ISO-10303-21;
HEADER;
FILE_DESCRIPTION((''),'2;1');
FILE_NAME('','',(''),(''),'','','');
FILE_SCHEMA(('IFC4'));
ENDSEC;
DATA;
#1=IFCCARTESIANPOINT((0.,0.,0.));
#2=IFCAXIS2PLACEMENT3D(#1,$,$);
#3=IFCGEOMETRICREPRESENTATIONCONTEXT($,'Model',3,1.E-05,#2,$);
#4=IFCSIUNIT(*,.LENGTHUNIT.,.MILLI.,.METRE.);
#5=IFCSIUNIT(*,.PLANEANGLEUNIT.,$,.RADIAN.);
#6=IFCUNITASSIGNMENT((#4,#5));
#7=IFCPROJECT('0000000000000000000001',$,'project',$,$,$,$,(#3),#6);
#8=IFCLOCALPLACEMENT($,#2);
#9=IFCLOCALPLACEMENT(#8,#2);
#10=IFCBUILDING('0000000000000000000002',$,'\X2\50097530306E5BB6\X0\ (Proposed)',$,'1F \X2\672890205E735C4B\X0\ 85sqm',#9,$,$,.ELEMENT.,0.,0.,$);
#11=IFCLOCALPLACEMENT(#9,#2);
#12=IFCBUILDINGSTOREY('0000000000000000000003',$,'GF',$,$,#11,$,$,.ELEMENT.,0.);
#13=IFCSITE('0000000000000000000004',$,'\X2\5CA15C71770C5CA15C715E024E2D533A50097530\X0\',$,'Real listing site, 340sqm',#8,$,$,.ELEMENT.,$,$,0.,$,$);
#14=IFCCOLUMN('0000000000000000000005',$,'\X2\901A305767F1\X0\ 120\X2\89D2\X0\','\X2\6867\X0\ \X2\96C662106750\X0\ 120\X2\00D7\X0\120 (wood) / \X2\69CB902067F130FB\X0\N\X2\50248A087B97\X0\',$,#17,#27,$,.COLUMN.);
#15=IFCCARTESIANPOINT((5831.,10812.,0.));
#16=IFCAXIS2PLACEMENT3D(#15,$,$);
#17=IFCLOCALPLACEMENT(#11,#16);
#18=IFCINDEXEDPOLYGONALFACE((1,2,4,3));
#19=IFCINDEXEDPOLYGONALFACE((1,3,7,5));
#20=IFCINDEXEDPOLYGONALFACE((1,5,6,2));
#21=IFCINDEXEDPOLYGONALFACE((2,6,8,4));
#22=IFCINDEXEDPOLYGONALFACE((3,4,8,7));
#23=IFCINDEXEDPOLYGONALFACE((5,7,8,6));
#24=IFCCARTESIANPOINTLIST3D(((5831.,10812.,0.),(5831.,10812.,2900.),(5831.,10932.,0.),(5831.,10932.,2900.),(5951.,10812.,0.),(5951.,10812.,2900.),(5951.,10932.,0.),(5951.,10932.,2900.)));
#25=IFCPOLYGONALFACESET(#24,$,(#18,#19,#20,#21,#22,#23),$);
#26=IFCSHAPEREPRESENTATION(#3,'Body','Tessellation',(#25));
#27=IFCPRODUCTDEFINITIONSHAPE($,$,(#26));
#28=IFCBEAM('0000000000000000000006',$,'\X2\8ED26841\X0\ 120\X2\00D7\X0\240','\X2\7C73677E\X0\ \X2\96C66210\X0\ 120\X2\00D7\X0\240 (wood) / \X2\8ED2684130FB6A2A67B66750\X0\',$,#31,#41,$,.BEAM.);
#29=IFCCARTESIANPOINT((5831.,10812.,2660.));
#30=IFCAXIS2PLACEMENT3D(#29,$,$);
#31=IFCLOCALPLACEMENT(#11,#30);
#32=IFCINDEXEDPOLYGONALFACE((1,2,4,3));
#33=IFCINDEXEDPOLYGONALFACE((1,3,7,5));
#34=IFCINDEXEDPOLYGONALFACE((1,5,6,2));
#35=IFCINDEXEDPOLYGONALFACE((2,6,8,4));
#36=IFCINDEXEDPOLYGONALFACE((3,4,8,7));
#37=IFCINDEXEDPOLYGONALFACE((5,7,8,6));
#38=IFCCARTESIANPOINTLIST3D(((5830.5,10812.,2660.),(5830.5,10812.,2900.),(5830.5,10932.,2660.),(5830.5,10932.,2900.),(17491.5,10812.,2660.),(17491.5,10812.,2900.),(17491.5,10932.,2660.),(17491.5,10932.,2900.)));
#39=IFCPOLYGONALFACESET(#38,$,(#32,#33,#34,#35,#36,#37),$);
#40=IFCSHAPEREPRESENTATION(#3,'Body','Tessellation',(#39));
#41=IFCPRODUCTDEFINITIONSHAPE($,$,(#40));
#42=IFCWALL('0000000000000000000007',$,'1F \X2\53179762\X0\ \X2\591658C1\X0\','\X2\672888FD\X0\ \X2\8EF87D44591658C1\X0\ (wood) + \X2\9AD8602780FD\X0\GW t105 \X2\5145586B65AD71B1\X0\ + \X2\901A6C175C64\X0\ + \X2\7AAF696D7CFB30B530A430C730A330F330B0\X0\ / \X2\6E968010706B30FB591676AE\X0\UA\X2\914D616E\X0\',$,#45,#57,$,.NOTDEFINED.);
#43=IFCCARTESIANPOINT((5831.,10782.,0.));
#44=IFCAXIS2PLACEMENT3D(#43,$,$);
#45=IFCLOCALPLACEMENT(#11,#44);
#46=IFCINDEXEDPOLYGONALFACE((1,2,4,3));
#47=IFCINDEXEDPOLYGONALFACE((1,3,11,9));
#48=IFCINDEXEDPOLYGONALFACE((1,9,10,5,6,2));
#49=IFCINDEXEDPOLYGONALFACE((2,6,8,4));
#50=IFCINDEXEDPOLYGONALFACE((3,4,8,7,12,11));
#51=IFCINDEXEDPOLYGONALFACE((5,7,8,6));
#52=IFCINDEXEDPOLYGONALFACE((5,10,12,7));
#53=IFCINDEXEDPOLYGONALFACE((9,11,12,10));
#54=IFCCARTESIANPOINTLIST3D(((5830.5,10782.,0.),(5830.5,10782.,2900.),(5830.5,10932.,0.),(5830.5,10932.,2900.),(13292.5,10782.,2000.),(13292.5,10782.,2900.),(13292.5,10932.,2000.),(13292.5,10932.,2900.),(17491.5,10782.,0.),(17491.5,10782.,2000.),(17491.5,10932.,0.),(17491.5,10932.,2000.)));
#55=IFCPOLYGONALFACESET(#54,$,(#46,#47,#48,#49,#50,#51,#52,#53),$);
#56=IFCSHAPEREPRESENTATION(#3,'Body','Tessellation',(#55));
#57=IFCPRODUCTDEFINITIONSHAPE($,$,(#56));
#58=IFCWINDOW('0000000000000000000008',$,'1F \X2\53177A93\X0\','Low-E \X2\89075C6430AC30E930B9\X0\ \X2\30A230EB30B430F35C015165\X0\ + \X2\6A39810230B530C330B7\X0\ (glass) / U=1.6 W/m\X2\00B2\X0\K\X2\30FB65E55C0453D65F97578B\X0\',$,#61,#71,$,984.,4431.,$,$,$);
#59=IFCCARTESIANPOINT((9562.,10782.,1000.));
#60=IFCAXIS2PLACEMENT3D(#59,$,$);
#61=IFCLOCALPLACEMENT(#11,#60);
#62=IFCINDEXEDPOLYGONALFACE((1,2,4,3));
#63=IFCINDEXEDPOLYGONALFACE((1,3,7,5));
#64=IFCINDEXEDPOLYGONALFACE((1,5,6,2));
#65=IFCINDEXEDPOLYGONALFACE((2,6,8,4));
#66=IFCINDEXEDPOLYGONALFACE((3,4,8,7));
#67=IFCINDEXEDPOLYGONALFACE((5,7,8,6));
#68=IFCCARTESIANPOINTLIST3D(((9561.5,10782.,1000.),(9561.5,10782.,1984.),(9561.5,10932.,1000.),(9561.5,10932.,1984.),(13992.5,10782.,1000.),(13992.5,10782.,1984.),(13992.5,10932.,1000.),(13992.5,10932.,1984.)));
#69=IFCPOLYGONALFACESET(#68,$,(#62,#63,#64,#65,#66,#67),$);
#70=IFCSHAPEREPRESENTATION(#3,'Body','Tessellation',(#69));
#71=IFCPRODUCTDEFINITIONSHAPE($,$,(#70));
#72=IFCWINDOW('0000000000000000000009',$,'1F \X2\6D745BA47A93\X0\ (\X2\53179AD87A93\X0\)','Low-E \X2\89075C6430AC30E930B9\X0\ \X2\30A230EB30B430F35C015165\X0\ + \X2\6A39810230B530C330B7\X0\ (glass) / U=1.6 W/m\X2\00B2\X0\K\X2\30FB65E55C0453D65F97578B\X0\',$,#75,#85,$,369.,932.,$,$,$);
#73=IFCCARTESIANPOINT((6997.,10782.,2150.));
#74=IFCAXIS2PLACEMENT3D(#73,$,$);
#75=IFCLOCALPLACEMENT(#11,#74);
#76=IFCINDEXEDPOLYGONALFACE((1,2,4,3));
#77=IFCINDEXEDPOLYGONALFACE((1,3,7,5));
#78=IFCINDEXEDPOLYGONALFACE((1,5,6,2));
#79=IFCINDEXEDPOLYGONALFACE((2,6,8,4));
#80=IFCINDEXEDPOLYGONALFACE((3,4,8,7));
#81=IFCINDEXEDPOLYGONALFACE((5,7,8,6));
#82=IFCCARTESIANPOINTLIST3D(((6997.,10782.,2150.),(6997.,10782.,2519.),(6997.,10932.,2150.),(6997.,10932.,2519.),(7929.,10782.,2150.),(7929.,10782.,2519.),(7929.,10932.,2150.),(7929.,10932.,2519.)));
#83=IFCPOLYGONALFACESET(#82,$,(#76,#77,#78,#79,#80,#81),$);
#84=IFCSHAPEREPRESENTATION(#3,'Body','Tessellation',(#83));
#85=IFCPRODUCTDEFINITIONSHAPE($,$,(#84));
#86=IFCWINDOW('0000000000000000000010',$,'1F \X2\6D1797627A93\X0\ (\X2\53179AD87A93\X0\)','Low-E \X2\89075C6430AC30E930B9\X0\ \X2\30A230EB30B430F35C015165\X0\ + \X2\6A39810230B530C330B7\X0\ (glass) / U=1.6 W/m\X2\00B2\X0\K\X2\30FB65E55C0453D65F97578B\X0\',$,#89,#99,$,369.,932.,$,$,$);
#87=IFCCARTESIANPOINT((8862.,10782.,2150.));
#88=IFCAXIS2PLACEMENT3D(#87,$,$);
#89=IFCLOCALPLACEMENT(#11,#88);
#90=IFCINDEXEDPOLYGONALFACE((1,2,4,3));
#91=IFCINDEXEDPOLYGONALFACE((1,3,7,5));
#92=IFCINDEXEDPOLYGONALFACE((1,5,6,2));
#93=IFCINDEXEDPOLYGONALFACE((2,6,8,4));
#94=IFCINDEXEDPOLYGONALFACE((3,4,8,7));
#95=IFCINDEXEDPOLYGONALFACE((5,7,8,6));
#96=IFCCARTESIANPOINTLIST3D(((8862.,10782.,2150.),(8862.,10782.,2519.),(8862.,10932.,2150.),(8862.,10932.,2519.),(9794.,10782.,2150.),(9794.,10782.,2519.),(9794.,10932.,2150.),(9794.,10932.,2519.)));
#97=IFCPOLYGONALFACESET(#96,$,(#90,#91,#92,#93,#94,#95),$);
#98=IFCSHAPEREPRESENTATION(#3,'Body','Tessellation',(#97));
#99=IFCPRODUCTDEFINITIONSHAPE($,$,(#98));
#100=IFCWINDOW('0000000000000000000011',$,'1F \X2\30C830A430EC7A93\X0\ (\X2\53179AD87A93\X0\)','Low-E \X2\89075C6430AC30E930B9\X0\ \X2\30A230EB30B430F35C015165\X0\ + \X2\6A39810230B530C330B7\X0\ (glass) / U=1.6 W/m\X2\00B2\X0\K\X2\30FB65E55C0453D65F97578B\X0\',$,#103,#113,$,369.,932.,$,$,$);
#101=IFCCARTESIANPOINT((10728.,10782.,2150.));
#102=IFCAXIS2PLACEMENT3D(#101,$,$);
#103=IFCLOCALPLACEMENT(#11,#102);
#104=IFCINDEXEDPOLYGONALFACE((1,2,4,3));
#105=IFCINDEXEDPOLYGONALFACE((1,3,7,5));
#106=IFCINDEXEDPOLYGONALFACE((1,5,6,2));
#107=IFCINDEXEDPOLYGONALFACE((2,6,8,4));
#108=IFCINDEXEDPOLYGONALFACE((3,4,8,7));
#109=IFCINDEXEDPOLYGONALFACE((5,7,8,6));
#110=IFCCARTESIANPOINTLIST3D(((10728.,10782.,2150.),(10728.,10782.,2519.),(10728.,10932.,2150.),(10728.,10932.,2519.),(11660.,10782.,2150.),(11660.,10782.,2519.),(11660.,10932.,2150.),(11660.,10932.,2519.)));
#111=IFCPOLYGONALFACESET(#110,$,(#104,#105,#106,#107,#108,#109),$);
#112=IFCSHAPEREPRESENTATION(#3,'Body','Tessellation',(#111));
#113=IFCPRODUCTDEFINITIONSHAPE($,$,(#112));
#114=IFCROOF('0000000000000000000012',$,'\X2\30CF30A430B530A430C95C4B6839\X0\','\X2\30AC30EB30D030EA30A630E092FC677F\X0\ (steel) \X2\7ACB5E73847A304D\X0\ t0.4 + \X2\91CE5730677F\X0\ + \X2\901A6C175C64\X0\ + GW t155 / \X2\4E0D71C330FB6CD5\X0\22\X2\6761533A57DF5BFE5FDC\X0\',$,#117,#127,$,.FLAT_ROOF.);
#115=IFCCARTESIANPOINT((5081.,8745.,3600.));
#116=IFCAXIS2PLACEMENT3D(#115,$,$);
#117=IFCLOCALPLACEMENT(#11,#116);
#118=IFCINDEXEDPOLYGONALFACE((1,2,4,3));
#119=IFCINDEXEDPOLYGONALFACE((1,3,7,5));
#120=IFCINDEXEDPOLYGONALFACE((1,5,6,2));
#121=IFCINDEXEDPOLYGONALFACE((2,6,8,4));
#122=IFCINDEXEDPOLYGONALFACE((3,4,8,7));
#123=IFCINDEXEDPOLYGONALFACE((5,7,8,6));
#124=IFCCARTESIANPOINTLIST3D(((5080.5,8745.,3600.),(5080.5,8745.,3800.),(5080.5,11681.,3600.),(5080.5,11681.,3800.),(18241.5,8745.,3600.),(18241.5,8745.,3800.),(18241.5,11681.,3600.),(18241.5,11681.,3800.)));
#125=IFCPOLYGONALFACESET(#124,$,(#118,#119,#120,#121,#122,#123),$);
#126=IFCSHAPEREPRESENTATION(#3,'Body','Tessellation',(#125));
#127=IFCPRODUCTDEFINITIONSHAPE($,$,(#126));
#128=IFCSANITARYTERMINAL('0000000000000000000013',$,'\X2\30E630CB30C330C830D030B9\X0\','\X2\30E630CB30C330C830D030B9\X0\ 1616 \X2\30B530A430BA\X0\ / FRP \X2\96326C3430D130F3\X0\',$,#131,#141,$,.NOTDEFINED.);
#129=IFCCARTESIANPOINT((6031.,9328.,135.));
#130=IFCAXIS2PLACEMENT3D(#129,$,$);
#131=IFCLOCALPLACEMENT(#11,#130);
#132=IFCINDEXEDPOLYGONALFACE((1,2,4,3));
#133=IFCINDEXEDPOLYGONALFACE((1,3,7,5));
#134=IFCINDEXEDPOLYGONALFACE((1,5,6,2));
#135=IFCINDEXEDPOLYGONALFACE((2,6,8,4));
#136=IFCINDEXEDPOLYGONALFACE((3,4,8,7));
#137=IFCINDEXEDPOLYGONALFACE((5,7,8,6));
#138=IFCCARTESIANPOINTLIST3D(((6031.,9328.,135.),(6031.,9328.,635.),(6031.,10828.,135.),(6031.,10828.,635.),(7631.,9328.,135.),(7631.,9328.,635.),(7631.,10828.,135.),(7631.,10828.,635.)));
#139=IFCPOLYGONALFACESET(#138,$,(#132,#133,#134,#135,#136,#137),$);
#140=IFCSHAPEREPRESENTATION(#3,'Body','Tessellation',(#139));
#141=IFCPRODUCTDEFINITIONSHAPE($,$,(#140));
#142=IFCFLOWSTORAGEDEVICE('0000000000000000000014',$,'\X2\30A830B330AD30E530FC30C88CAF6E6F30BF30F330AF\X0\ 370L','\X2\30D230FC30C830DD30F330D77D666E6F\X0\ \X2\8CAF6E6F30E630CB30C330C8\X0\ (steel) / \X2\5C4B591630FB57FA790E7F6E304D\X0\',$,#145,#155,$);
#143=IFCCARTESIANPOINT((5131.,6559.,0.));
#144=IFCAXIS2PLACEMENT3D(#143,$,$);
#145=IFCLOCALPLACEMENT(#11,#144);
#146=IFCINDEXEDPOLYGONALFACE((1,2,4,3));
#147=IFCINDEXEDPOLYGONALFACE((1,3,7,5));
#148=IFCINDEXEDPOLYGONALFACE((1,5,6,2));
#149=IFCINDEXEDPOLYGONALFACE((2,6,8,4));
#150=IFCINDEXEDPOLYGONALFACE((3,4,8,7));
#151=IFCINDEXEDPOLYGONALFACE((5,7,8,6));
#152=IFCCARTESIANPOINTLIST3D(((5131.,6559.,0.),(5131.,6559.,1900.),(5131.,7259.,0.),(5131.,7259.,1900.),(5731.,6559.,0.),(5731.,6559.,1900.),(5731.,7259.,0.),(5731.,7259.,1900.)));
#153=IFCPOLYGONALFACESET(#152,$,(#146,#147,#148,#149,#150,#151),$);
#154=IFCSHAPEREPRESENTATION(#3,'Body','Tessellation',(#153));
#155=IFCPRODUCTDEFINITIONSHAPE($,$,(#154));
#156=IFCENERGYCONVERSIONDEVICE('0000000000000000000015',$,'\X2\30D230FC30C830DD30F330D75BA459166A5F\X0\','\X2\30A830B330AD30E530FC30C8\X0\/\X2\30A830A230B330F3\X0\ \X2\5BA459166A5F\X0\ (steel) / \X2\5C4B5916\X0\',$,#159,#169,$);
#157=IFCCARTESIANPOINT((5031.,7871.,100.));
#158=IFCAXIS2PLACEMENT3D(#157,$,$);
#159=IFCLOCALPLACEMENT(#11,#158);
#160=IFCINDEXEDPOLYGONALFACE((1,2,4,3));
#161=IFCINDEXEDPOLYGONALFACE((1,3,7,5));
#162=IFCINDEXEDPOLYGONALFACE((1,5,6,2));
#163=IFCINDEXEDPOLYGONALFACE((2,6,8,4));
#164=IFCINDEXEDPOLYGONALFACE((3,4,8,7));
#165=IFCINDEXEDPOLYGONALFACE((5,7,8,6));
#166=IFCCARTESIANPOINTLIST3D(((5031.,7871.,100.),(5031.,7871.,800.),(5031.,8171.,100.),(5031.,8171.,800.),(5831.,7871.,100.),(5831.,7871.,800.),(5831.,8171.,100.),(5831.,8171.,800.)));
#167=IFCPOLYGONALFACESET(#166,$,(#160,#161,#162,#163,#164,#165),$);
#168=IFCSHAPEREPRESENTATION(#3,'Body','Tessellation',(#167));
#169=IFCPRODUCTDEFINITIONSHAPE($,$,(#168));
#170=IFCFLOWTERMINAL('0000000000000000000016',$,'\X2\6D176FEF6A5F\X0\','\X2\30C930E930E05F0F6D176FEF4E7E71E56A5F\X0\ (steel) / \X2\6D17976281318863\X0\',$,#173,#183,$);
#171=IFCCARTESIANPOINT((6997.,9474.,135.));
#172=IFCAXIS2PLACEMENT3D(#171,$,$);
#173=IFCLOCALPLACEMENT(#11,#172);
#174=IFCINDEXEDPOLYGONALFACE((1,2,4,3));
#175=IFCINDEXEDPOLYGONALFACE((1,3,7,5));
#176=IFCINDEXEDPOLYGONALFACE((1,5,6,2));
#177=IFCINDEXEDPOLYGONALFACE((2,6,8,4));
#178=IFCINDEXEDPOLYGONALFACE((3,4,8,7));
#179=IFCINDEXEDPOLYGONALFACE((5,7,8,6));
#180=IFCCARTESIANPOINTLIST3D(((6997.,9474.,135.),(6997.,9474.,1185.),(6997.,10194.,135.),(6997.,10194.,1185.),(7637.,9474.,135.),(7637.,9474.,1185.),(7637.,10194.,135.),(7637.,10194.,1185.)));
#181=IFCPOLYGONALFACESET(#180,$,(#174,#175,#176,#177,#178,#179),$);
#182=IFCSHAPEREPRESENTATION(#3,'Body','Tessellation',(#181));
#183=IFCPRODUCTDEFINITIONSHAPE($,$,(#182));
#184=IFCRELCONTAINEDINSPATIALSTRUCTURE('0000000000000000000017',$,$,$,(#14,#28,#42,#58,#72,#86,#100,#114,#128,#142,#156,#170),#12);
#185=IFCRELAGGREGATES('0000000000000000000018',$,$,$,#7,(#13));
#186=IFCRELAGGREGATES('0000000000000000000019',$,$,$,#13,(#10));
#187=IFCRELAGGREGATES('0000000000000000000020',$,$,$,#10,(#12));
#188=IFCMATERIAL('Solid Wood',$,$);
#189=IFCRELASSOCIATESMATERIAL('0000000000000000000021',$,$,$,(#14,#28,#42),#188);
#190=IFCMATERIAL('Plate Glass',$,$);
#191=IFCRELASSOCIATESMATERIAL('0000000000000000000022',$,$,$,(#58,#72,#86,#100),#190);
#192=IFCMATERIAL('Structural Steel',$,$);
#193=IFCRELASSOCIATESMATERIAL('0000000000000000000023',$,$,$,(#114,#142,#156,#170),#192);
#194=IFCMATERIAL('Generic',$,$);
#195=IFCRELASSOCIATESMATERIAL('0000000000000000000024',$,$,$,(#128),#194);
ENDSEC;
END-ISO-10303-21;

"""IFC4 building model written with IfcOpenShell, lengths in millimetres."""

from ifc_helpers import new_model, si_unit, frame, frame_2d, origin, place, context, project, spatial, rectangle, extrude, material, element, fill, save


model = new_model("IFC4")

# Units and contexts
model_context = context("Model", 3, precision=1e-05, world=origin())
ifc_project = project(units=[si_unit("LENGTHUNIT", "METRE", prefix="MILLI"), si_unit("PLANEANGLEUNIT", "RADIAN")], contexts=[model_context])

# Site, building, storey
site_placement = place(None, origin())
site = spatial("IfcSite", under=ifc_project, at=site_placement, Name="岡山県岡山市中区倉田", ObjectType="Real listing site, 340sqm", CompositionType="ELEMENT", RefElevation=0.0)
building_placement = place(site_placement, origin())
building = spatial("IfcBuilding", under=site, at=building_placement, Name="倉田の家 (Proposed)", ObjectType="1F 木造平屋 85sqm", CompositionType="ELEMENT", ElevationOfRefHeight=0.0, ElevationOfTerrain=0.0)
storey_placement = place(building_placement, origin())
storey = spatial("IfcBuildingStorey", under=building, at=storey_placement, Name="GF", CompositionType="ELEMENT", Elevation=0.0)

# Column
ifc_material_1 = material(Name="Solid Wood")
column_1_placement = place(storey_placement, frame((5831.0, 10812.0, 0.0)))
element("IfcColumn", 1, at=column_1_placement, inside=storey, material=ifc_material_1, Name="通し柱 120角", Description="桧 集成材 120×120 (wood) / 構造柱・N値計算", PredefinedType="COLUMN", context=model_context, shape_type="SweptSolid", body=[
    extrude(rectangle(XDim=120.0, YDim=120.0, at=frame_2d((60.0, 60.0))), frame((5831.0, 10812.0, 0.0)), (0.0, 0.0, 1.0), 2900.0),
])

# Beam
beam_1_placement = place(storey_placement, frame((5831.0, 10812.0, 2660.0)))
element("IfcBeam", 2, at=beam_1_placement, inside=storey, material=ifc_material_1, Name="軒桁 120×240", Description="米松 集成 120×240 (wood) / 軒桁・横架材", PredefinedType="BEAM", context=model_context, shape_type="SweptSolid", body=[
    extrude(rectangle(XDim=11661.0, YDim=120.0, at=frame_2d((5830.0, 60.0))), frame((5831.0, 10812.0, 2660.0)), (0.0, 0.0, 1.0), 240.0),
])

# Wall, openings, windows
wall_1_placement = place(storey_placement, frame((5831.0, 10782.0, 0.0)))
wall_1 = element("IfcWall", 3, at=wall_1_placement, inside=storey, material=ifc_material_1, Name="1F 北面 外壁", Description="木製 軸組外壁 (wood) + 高性能GW t105 充填断熱 + 通気層 + 窯業系サイディング / 準耐火・外皮UA配慮", PredefinedType="NOTDEFINED", context=model_context, shape_type="SweptSolid", body=[
    extrude(rectangle(XDim=11661.0, YDim=150.0, at=frame_2d((5830.0, 75.0))), frame((5831.0, 10782.0, 0.0)), (0.0, 0.0, 1.0), 2900.0),
])
opening_1_placement = place(storey_placement, frame((9562.0, 10782.0, 1000.0)))
opening_1 = element("IfcOpeningElement", 4, at=opening_1_placement, cuts=wall_1, PredefinedType="NOTDEFINED", context=model_context, shape_type="SweptSolid", body=[
    extrude(rectangle(XDim=4431.0, YDim=150.0, at=frame_2d((2215.0, 75.0))), frame((9562.0, 10782.0, 1000.0)), (0.0, 0.0, 1.0), 984.0),
])
opening_2_placement = place(storey_placement, frame((6997.0, 10782.0, 2150.0)))
opening_2 = element("IfcOpeningElement", 5, at=opening_2_placement, cuts=wall_1, PredefinedType="NOTDEFINED", context=model_context, shape_type="SweptSolid", body=[
    extrude(rectangle(XDim=932.0, YDim=150.0, at=frame_2d((466.0, 75.0))), frame((6997.0, 10782.0, 2150.0)), (0.0, 0.0, 1.0), 369.0),
])
opening_3_placement = place(storey_placement, frame((8862.0, 10782.0, 2150.0)))
opening_3 = element("IfcOpeningElement", 6, at=opening_3_placement, cuts=wall_1, PredefinedType="NOTDEFINED", context=model_context, shape_type="SweptSolid", body=[
    extrude(rectangle(XDim=932.0, YDim=150.0, at=frame_2d((466.0, 75.0))), frame((8862.0, 10782.0, 2150.0)), (0.0, 0.0, 1.0), 369.0),
])
opening_4_placement = place(storey_placement, frame((10728.0, 10782.0, 2150.0)))
opening_4 = element("IfcOpeningElement", 7, at=opening_4_placement, cuts=wall_1, PredefinedType="NOTDEFINED", context=model_context, shape_type="SweptSolid", body=[
    extrude(rectangle(XDim=932.0, YDim=150.0, at=frame_2d((466.0, 75.0))), frame((10728.0, 10782.0, 2150.0)), (0.0, 0.0, 1.0), 369.0),
])
ifc_material_2 = material(Name="Plate Glass")
window_1_placement = place(storey_placement, frame((9562.0, 10782.0, 1000.0)))
window_1 = element("IfcWindow", 8, at=window_1_placement, inside=storey, material=ifc_material_2, Name="1F 北窓", Description="Low-E 複層ガラス アルゴン封入 + 樹脂サッシ (glass) / U=1.6 W/m²K・日射取得型", OverallHeight=984.0, OverallWidth=4431.0, context=model_context, shape_type="SweptSolid", body=[
    extrude(rectangle(XDim=4431.0, YDim=150.0, at=frame_2d((2215.0, 75.0))), frame((9562.0, 10782.0, 1000.0)), (0.0, 0.0, 1.0), 984.0),
])
fill(opening_1, window_1)
window_2_placement = place(storey_placement, frame((6997.0, 10782.0, 2150.0)))
window_2 = element("IfcWindow", 9, at=window_2_placement, inside=storey, material=ifc_material_2, Name="1F 浴室窓 (北高窓)", Description="Low-E 複層ガラス アルゴン封入 + 樹脂サッシ (glass) / U=1.6 W/m²K・日射取得型", OverallHeight=369.0, OverallWidth=932.0, context=model_context, shape_type="SweptSolid", body=[
    extrude(rectangle(XDim=932.0, YDim=150.0, at=frame_2d((466.0, 75.0))), frame((6997.0, 10782.0, 2150.0)), (0.0, 0.0, 1.0), 369.0),
])
fill(opening_2, window_2)
window_3_placement = place(storey_placement, frame((8862.0, 10782.0, 2150.0)))
window_3 = element("IfcWindow", 10, at=window_3_placement, inside=storey, material=ifc_material_2, Name="1F 洗面窓 (北高窓)", Description="Low-E 複層ガラス アルゴン封入 + 樹脂サッシ (glass) / U=1.6 W/m²K・日射取得型", OverallHeight=369.0, OverallWidth=932.0, context=model_context, shape_type="SweptSolid", body=[
    extrude(rectangle(XDim=932.0, YDim=150.0, at=frame_2d((466.0, 75.0))), frame((8862.0, 10782.0, 2150.0)), (0.0, 0.0, 1.0), 369.0),
])
fill(opening_3, window_3)
window_4_placement = place(storey_placement, frame((10728.0, 10782.0, 2150.0)))
window_4 = element("IfcWindow", 11, at=window_4_placement, inside=storey, material=ifc_material_2, Name="1F トイレ窓 (北高窓)", Description="Low-E 複層ガラス アルゴン封入 + 樹脂サッシ (glass) / U=1.6 W/m²K・日射取得型", OverallHeight=369.0, OverallWidth=932.0, context=model_context, shape_type="SweptSolid", body=[
    extrude(rectangle(XDim=932.0, YDim=150.0, at=frame_2d((466.0, 75.0))), frame((10728.0, 10782.0, 2150.0)), (0.0, 0.0, 1.0), 369.0),
])
fill(opening_4, window_4)

# Roof
ifc_material_3 = material(Name="Structural Steel")
roof_placement = place(storey_placement, frame((5081.0, 8745.0, 3600.0)))
element("IfcRoof", 12, at=roof_placement, inside=storey, material=ifc_material_3, Name="ハイサイド屋根", Description="ガルバリウム鋼板 (steel) 立平葺き t0.4 + 野地板 + 通気層 + GW t155 / 不燃・法22条区域対応", PredefinedType="FLAT_ROOF", context=model_context, shape_type="SweptSolid", body=[
    extrude(rectangle(XDim=13161.0, YDim=2936.0, at=frame_2d((6580.0, 1468.0))), frame((5081.0, 8745.0, 3600.0)), (0.0, 0.0, 1.0), 200.0),
])

# Sanitary terminal
ifc_material_4 = material(Name="Generic")
sanitary_terminal_placement = place(storey_placement, frame((6031.0, 9328.0, 135.0)))
element("IfcSanitaryTerminal", 13, at=sanitary_terminal_placement, inside=storey, material=ifc_material_4, Name="ユニットバス", Description="ユニットバス 1616 サイズ / FRP 防水パン", PredefinedType="NOTDEFINED", context=model_context, shape_type="SweptSolid", body=[
    extrude(rectangle(XDim=1600.0, YDim=1500.0, at=frame_2d((800.0, 750.0))), frame((6031.0, 9328.0, 135.0)), (0.0, 0.0, 1.0), 500.0),
])

# Flow storage device
flow_storage_device_placement = place(storey_placement, frame((5131.0, 6559.0, 0.0)))
element("IfcFlowStorageDevice", 14, at=flow_storage_device_placement, inside=storey, material=ifc_material_3, Name="エコキュート貯湯タンク 370L", Description="ヒートポンプ給湯 貯湯ユニット (steel) / 屋外・基礎置き", context=model_context, shape_type="SweptSolid", body=[
    extrude(rectangle(XDim=600.0, YDim=700.0, at=frame_2d((300.0, 350.0))), frame((5131.0, 6559.0, 0.0)), (0.0, 0.0, 1.0), 1900.0),
])

# Energy conversion device
energy_conversion_device_placement = place(storey_placement, frame((5031.0, 7871.0, 100.0)))
element("IfcEnergyConversionDevice", 15, at=energy_conversion_device_placement, inside=storey, material=ifc_material_3, Name="ヒートポンプ室外機", Description="エコキュート/エアコン 室外機 (steel) / 屋外", context=model_context, shape_type="SweptSolid", body=[
    extrude(rectangle(XDim=800.0, YDim=300.0, at=frame_2d((400.0, 150.0))), frame((5031.0, 7871.0, 100.0)), (0.0, 0.0, 1.0), 700.0),
])

# Flow terminal
flow_terminal_placement = place(storey_placement, frame((6997.0, 9474.0, 135.0)))
element("IfcFlowTerminal", 16, at=flow_terminal_placement, inside=storey, material=ifc_material_3, Name="洗濯機", Description="ドラム式洗濯乾燥機 (steel) / 洗面脱衣", context=model_context, shape_type="SweptSolid", body=[
    extrude(rectangle(XDim=640.0, YDim=720.0, at=frame_2d((320.0, 360.0))), frame((6997.0, 9474.0, 135.0)), (0.0, 0.0, 1.0), 1050.0),
])

save(model, "model.ifc")
